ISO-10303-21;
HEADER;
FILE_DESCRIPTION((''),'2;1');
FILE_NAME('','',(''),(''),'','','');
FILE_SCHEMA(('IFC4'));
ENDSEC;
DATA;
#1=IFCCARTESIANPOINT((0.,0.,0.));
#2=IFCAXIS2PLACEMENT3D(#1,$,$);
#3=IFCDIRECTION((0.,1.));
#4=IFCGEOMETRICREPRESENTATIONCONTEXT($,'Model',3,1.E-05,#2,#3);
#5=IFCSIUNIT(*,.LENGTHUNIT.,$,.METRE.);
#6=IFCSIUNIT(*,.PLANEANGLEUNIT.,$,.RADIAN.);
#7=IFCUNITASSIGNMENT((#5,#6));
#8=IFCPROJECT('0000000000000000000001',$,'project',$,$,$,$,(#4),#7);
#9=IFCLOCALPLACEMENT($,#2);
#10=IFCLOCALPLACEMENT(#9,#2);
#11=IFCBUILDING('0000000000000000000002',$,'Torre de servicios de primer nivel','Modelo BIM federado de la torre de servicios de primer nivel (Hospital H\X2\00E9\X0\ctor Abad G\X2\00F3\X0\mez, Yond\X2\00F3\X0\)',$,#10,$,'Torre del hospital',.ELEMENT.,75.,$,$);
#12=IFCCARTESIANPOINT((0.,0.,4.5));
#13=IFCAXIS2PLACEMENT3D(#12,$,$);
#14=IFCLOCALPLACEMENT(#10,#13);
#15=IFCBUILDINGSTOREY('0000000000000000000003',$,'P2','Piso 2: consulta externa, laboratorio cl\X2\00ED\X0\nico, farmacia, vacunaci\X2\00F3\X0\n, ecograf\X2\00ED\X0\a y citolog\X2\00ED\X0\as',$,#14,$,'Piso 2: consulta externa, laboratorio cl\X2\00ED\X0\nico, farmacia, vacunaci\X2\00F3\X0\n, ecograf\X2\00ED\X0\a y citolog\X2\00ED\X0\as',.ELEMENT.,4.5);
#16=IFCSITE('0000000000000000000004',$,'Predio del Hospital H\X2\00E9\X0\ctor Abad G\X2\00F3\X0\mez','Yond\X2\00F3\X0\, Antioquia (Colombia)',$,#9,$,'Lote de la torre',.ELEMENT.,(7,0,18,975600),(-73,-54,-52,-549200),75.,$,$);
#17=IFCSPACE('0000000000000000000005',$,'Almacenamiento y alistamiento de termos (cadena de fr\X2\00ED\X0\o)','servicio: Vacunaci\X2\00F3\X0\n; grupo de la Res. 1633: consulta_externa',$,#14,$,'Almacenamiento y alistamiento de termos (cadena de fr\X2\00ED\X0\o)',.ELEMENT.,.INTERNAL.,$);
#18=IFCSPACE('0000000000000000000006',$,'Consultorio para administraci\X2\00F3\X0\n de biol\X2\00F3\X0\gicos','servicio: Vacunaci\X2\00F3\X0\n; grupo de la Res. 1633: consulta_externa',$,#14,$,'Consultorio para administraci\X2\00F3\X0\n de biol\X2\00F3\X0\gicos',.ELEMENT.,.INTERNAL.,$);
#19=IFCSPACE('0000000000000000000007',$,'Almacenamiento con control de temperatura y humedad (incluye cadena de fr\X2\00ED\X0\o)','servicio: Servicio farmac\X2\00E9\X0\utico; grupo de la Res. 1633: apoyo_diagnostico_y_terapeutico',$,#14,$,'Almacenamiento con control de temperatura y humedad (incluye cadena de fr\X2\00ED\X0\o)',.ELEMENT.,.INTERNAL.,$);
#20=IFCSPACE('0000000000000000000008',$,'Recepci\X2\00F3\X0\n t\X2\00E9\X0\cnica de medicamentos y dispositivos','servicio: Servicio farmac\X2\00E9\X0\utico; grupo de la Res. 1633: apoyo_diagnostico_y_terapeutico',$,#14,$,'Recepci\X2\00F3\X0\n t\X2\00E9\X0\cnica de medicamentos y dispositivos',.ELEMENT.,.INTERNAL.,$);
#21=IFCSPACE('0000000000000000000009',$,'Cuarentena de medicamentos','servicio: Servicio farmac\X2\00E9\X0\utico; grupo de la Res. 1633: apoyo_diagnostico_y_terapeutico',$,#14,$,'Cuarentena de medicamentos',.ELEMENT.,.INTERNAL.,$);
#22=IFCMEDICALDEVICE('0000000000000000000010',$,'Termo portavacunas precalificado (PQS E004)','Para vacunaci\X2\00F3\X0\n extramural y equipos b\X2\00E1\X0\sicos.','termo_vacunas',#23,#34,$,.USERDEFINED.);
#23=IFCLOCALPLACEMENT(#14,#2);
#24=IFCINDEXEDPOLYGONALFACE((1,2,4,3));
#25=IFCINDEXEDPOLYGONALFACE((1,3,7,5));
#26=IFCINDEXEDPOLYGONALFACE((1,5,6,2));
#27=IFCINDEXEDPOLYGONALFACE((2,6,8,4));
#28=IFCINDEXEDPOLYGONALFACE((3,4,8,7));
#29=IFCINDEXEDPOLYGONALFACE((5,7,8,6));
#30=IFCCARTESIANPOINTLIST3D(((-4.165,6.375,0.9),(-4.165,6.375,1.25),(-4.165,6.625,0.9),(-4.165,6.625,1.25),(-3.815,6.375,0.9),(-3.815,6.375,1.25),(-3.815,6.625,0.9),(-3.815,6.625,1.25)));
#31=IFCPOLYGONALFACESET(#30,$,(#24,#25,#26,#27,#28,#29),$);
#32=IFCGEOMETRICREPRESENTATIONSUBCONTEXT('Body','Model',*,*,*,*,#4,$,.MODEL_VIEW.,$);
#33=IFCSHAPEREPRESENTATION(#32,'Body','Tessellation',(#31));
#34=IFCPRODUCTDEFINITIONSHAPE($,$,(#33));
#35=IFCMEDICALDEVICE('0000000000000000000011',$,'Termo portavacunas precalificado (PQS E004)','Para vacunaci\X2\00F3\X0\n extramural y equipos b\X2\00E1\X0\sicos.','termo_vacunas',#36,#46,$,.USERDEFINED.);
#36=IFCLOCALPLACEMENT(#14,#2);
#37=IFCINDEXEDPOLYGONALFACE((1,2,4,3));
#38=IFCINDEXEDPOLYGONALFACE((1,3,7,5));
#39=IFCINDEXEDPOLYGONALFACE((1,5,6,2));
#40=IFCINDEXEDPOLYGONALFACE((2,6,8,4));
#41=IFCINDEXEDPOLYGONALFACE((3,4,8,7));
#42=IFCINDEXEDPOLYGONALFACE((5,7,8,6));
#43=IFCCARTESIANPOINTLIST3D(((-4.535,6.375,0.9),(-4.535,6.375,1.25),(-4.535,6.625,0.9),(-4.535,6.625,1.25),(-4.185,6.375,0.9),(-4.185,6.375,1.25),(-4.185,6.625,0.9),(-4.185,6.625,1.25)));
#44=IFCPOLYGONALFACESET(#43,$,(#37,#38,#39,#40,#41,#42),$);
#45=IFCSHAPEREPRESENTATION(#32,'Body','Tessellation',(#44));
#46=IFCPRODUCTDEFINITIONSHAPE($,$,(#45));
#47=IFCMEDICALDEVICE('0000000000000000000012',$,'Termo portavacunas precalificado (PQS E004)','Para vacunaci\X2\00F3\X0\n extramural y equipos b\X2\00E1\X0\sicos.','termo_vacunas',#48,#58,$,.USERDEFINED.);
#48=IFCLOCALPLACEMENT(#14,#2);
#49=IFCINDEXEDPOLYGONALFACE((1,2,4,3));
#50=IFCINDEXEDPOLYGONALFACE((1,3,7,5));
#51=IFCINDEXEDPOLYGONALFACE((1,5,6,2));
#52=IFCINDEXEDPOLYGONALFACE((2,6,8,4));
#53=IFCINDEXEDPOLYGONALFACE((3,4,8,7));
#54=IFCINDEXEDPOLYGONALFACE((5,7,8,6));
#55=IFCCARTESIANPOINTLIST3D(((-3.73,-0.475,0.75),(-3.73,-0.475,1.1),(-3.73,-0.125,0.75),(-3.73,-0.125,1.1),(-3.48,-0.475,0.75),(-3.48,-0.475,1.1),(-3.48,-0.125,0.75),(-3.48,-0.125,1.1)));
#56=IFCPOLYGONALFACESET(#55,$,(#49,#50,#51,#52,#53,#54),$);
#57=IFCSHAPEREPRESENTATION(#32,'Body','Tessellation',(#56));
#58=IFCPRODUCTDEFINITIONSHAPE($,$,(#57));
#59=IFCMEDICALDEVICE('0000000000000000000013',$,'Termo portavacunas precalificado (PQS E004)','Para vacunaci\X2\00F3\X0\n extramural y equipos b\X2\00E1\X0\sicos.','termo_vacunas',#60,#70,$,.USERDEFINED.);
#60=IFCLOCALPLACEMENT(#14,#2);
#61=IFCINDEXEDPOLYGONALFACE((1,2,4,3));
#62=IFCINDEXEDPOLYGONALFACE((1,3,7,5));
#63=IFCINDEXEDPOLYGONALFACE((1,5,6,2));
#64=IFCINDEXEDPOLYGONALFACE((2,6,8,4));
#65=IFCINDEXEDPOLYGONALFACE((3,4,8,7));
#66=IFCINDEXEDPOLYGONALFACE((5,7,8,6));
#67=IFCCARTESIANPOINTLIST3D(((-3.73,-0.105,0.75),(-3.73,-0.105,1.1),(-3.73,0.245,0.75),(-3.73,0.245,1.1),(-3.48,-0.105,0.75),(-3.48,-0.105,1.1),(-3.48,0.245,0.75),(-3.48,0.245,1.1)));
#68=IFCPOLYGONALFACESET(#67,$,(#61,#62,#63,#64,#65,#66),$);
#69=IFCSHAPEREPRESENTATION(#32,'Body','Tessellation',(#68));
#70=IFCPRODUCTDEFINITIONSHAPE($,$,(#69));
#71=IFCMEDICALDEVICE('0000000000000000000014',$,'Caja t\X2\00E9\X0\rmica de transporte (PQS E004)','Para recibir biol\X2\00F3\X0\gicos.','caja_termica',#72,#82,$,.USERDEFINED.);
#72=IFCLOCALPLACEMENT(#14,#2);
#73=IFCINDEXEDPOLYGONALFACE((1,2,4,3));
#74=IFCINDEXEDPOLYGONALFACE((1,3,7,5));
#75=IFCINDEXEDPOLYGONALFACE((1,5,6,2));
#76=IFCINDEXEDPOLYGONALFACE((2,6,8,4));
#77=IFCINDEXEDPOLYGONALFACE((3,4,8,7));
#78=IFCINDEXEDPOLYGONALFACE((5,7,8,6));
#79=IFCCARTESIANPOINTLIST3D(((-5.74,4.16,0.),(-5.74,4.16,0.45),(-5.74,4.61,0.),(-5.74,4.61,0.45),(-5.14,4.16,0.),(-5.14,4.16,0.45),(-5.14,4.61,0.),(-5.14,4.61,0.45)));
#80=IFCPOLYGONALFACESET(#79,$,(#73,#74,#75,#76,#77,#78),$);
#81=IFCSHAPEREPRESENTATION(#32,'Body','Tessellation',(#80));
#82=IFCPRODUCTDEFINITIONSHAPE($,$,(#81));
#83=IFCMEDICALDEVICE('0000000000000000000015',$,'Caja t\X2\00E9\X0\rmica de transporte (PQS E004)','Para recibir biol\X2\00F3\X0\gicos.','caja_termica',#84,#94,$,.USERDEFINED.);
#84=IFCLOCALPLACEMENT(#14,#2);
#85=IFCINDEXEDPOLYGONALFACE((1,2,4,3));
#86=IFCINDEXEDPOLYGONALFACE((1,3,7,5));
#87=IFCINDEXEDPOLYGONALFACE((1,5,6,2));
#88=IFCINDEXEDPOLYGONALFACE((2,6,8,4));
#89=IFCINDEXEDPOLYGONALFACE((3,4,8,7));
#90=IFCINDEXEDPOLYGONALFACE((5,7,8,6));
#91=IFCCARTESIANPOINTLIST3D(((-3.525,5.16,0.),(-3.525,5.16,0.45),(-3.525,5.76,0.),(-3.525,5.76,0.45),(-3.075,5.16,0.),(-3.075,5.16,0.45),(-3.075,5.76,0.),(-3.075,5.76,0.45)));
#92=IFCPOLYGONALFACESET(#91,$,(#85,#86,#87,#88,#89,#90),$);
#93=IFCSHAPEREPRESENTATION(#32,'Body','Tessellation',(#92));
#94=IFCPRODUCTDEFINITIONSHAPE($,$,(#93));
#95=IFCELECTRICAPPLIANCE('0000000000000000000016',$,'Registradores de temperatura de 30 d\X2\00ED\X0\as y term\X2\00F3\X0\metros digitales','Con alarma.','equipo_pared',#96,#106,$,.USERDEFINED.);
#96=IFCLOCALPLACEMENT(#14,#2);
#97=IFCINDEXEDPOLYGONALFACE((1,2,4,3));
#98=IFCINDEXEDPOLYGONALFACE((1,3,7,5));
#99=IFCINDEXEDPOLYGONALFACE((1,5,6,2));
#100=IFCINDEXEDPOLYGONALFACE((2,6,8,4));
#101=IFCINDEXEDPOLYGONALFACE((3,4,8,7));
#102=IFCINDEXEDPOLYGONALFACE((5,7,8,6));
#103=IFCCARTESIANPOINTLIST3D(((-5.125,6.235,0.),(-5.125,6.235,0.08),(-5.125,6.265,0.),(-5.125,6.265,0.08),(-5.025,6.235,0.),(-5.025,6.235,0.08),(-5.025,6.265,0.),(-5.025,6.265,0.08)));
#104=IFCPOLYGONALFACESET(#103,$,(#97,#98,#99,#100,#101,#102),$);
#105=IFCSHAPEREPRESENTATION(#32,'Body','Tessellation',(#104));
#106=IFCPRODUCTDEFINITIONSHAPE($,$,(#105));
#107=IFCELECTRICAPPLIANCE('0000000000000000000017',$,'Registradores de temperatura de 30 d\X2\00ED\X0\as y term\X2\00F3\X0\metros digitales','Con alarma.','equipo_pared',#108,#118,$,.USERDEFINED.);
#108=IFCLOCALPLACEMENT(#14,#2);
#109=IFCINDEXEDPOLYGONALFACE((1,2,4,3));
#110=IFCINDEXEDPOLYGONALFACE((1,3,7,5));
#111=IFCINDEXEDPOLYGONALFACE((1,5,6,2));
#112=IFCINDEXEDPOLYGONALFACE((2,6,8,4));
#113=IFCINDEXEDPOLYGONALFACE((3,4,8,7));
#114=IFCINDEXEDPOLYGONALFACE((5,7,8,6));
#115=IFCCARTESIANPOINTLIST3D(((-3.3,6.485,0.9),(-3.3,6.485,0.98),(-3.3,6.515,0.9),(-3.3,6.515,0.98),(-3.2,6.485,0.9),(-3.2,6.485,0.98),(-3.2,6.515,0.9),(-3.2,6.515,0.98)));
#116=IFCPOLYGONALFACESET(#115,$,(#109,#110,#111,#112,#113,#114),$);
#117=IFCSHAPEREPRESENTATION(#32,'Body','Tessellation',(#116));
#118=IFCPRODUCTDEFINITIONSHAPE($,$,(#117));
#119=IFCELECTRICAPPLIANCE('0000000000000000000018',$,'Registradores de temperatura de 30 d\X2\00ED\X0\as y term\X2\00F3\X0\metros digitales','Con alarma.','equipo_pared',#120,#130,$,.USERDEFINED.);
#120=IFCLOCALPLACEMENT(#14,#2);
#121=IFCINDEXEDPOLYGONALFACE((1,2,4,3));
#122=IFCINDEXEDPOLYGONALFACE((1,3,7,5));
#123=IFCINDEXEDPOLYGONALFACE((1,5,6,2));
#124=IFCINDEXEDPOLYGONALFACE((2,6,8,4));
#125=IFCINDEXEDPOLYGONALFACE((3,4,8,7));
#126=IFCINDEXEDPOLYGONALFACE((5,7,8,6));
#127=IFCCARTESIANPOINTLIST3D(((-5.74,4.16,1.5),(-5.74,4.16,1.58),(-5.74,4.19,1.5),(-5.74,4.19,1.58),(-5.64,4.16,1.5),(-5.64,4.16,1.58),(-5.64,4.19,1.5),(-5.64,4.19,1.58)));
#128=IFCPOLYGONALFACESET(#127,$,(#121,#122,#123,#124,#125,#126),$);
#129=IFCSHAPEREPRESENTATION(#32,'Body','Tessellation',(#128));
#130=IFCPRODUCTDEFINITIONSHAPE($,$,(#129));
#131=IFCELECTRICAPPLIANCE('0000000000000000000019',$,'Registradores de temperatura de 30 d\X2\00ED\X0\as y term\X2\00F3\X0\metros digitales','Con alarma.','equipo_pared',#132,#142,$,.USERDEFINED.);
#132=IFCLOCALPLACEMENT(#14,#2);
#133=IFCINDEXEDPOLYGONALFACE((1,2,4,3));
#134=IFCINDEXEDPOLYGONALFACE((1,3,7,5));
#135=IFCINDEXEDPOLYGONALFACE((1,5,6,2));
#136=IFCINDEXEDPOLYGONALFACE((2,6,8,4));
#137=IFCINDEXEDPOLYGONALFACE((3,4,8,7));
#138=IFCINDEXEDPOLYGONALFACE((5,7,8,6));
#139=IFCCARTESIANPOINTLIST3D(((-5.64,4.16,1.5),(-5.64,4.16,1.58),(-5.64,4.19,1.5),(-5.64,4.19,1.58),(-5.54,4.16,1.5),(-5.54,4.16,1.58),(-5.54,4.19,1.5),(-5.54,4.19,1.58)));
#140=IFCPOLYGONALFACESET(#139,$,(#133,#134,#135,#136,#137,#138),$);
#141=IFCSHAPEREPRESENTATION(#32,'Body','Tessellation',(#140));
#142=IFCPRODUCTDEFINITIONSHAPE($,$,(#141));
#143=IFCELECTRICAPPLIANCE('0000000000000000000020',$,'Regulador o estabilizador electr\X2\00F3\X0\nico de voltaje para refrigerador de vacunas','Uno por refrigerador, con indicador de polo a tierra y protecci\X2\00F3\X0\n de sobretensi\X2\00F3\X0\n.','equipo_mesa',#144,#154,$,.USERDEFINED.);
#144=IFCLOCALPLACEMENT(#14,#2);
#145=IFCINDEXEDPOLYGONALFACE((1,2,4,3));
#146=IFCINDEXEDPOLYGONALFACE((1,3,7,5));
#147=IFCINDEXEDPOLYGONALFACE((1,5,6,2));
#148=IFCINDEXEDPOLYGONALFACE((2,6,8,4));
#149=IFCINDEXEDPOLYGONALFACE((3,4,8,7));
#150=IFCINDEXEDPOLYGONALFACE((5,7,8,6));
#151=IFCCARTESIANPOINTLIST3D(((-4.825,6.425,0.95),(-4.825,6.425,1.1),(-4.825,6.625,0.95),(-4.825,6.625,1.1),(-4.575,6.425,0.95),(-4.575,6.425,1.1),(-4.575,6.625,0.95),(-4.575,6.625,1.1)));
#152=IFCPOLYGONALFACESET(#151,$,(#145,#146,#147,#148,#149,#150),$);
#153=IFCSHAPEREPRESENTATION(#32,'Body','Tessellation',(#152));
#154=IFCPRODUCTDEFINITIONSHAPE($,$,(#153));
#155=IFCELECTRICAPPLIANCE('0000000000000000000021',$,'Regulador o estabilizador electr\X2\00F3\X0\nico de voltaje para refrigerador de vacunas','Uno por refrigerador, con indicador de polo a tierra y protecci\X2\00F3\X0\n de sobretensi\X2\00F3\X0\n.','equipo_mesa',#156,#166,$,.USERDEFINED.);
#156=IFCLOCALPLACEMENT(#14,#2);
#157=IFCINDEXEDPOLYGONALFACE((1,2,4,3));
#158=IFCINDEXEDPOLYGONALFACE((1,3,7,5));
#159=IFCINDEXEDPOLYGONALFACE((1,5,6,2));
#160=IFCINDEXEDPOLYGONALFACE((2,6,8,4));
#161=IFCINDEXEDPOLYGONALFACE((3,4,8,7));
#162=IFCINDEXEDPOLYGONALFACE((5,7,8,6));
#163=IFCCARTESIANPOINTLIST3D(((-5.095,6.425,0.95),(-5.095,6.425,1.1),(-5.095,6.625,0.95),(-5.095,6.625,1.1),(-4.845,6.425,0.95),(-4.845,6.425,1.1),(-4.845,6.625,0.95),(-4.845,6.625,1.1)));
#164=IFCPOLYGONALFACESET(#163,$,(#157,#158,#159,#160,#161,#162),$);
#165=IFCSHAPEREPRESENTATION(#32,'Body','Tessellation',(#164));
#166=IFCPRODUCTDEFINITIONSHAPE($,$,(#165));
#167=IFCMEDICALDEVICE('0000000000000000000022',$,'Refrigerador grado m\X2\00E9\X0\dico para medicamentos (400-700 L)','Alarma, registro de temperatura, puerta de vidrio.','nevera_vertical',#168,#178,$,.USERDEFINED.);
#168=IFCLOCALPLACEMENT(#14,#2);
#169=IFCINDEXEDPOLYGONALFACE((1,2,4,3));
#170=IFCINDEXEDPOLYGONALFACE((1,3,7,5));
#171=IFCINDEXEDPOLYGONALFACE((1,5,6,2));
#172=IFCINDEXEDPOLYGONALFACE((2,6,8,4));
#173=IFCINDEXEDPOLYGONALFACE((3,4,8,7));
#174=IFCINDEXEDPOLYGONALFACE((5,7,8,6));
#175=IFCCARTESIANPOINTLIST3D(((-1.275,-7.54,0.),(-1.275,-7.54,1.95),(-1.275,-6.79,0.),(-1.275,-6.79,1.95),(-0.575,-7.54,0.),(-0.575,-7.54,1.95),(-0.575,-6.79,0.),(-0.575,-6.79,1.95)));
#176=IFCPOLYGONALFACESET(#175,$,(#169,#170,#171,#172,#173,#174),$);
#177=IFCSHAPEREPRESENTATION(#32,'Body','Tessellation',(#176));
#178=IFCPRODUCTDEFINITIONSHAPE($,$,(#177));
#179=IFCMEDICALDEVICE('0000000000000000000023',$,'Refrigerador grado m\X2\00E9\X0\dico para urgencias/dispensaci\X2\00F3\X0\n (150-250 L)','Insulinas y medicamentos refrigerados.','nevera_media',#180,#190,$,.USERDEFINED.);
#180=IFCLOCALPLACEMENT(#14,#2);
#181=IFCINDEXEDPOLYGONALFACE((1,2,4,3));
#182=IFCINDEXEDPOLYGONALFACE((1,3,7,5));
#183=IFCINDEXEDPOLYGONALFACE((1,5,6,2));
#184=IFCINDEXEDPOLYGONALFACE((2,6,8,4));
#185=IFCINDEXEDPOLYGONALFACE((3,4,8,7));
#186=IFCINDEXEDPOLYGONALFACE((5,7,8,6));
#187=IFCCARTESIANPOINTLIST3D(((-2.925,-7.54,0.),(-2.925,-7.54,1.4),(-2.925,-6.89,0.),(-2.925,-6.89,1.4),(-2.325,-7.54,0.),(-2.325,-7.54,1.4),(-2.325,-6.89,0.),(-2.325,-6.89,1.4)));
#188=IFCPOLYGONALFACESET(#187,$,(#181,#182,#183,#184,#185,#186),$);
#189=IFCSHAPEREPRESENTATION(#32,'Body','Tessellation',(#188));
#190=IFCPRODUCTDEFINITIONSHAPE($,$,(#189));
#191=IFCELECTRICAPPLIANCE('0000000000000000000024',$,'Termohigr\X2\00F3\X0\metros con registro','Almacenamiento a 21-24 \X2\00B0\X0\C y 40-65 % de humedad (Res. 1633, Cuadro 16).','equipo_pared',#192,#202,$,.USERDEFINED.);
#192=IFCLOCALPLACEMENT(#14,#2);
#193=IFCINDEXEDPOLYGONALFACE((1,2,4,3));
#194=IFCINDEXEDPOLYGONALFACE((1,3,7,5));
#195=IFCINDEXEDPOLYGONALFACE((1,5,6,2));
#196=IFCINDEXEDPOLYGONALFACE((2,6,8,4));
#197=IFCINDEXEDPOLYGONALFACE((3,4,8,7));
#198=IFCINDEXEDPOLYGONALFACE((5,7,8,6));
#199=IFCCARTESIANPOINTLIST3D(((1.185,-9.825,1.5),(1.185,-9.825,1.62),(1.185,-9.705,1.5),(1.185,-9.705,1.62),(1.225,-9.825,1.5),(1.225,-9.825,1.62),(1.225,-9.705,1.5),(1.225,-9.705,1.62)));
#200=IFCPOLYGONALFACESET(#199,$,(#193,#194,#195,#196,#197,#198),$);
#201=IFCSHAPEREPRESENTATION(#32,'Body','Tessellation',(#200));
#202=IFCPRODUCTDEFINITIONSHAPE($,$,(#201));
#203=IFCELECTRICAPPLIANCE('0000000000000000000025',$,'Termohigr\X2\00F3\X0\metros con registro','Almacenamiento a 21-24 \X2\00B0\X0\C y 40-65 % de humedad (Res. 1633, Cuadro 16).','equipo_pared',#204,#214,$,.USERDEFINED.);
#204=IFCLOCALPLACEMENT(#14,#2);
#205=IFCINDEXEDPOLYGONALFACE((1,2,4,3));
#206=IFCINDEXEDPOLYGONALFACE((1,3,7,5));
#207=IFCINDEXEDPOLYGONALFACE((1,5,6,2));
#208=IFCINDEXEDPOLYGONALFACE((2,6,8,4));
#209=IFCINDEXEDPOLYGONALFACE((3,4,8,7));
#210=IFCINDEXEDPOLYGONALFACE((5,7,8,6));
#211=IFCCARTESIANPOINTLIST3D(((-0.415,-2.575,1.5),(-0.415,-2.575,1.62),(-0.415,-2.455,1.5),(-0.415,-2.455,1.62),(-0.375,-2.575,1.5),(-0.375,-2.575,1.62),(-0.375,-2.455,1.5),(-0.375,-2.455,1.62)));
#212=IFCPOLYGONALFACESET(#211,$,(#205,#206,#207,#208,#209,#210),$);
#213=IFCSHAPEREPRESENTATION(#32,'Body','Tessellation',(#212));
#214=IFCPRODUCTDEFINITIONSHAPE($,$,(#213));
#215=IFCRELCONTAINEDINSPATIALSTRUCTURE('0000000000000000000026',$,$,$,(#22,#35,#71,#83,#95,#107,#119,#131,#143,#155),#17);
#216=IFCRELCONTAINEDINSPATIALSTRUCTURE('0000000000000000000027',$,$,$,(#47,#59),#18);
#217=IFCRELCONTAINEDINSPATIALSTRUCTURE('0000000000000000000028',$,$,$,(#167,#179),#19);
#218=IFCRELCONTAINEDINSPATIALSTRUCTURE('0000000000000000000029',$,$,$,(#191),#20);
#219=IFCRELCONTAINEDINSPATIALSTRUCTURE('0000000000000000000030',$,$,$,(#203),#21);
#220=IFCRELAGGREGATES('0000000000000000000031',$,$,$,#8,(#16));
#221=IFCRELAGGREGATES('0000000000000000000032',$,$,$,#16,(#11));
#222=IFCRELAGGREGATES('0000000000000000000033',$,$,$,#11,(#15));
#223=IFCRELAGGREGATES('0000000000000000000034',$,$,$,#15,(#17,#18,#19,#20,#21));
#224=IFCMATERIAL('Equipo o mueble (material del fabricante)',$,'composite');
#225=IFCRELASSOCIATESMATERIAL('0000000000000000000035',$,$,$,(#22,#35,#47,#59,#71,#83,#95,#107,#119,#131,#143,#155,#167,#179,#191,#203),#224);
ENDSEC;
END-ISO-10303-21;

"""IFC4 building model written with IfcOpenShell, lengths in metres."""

from ifc_helpers import new_model, si_unit, direction, frame, origin, place, context, subcontext, project, spatial, rectangle, extrude, material, element, save


model = new_model("IFC4")

# Units and contexts
model_context = context("Model", 3, precision=1e-05, world=origin(), true_north=direction((0.0, 1.0)))
body_context = subcontext(model_context, "Body", "Model", "MODEL_VIEW")
ifc_project = project(units=[si_unit("LENGTHUNIT", "METRE"), si_unit("PLANEANGLEUNIT", "RADIAN")], contexts=[model_context])

# Site, building, storey, space
site_placement = place(None, origin())
site = spatial("IfcSite", under=ifc_project, at=site_placement, Name="Predio del Hospital Héctor Abad Gómez", Description="Yondó, Antioquia (Colombia)", LongName="Lote de la torre", CompositionType="ELEMENT", RefLatitude=(7, 0, 18, 975600), RefLongitude=(-73, -54, -52, -549200), RefElevation=75.0)
building_placement = place(site_placement, origin())
building = spatial("IfcBuilding", under=site, at=building_placement, Name="Torre de servicios de primer nivel", Description="Modelo BIM federado de la torre de servicios de primer nivel (Hospital Héctor Abad Gómez, Yondó)", LongName="Torre del hospital", CompositionType="ELEMENT", ElevationOfRefHeight=75.0)
placement = place(building_placement, frame((0.0, 0.0, 4.5)))
storey = spatial("IfcBuildingStorey", under=building, at=placement, Name="P2", Description="Piso 2: consulta externa, laboratorio clínico, farmacia, vacunación, ecografía y citologías", LongName="Piso 2: consulta externa, laboratorio clínico, farmacia, vacunación, ecografía y citologías", CompositionType="ELEMENT", Elevation=4.5)
space_1 = spatial("IfcSpace", under=storey, at=placement, Name="Almacenamiento y alistamiento de termos (cadena de frío)", Description="servicio: Vacunación; grupo de la Res. 1633: consulta_externa", LongName="Almacenamiento y alistamiento de termos (cadena de frío)", CompositionType="ELEMENT", PredefinedType="INTERNAL")

# Medical devices
ifc_material = material(Name="Equipo o mueble (material del fabricante)", Category="composite")
element("IfcMedicalDevice", 1, at=placement, inside=space_1, material=ifc_material, Name="Termo portavacunas precalificado (PQS E004)", Description="Para vacunación extramural y equipos básicos.", ObjectType="termo_vacunas", PredefinedType="USERDEFINED", context=body_context, shape_type="SweptSolid", body=[
    extrude(rectangle(XDim=0.35, YDim=0.25), frame((-3.99, 6.5, 0.9), z_axis=(0.0, 0.0, 1.0), x_axis=(-1.0, 0.0, 0.0)), (0.0, 0.0, 1.0), 0.35),
])
element("IfcMedicalDevice", 2, at=placement, inside=space_1, material=ifc_material, Name="Termo portavacunas precalificado (PQS E004)", Description="Para vacunación extramural y equipos básicos.", ObjectType="termo_vacunas", PredefinedType="USERDEFINED", context=body_context, shape_type="SweptSolid", body=[
    extrude(rectangle(XDim=0.35, YDim=0.25), frame((-4.36, 6.5, 0.9), z_axis=(0.0, 0.0, 1.0), x_axis=(-1.0, 0.0, 0.0)), (0.0, 0.0, 1.0), 0.35),
])

# Shared definitions
space_2 = spatial("IfcSpace", under=storey, at=placement, Name="Consultorio para administración de biológicos", Description="servicio: Vacunación; grupo de la Res. 1633: consulta_externa", LongName="Consultorio para administración de biológicos", CompositionType="ELEMENT", PredefinedType="INTERNAL")

# Medical devices
element("IfcMedicalDevice", 3, at=placement, inside=space_2, material=ifc_material, Name="Termo portavacunas precalificado (PQS E004)", Description="Para vacunación extramural y equipos básicos.", ObjectType="termo_vacunas", PredefinedType="USERDEFINED", context=body_context, shape_type="SweptSolid", body=[
    extrude(rectangle(XDim=0.35, YDim=0.25), frame((-3.605, -0.3, 0.75), z_axis=(0.0, 0.0, 1.0), x_axis=(0.0, 1.0, 0.0)), (0.0, 0.0, 1.0), 0.35),
])
element("IfcMedicalDevice", 4, at=placement, inside=space_2, material=ifc_material, Name="Termo portavacunas precalificado (PQS E004)", Description="Para vacunación extramural y equipos básicos.", ObjectType="termo_vacunas", PredefinedType="USERDEFINED", context=body_context, shape_type="SweptSolid", body=[
    extrude(rectangle(XDim=0.35, YDim=0.25), frame((-3.605, 0.07, 0.75), z_axis=(0.0, 0.0, 1.0), x_axis=(0.0, 1.0, 0.0)), (0.0, 0.0, 1.0), 0.35),
])
element("IfcMedicalDevice", 5, at=placement, inside=space_1, material=ifc_material, Name="Caja térmica de transporte (PQS E004)", Description="Para recibir biológicos.", ObjectType="caja_termica", PredefinedType="USERDEFINED", context=body_context, shape_type="SweptSolid", body=[
    extrude(rectangle(XDim=0.6, YDim=0.45), frame((-5.44, 4.385, 0.0)), (0.0, 0.0, 1.0), 0.45),
])
element("IfcMedicalDevice", 6, at=placement, inside=space_1, material=ifc_material, Name="Caja térmica de transporte (PQS E004)", Description="Para recibir biológicos.", ObjectType="caja_termica", PredefinedType="USERDEFINED", context=body_context, shape_type="SweptSolid", body=[
    extrude(rectangle(XDim=0.6, YDim=0.45), frame((-3.3, 5.46, 0.0), z_axis=(0.0, 0.0, 1.0), x_axis=(0.0, 1.0, 0.0)), (0.0, 0.0, 1.0), 0.45),
])

# Electric appliances
element("IfcElectricAppliance", 7, at=placement, inside=space_1, material=ifc_material, Name="Registradores de temperatura de 30 días y termómetros digitales", Description="Con alarma.", ObjectType="equipo_pared", PredefinedType="USERDEFINED", context=body_context, shape_type="SweptSolid", body=[
    extrude(rectangle(XDim=0.1, YDim=0.03), frame((-5.075, 6.25, 0.0), z_axis=(0.0, 0.0, 1.0), x_axis=(-1.0, 0.0, 0.0)), (0.0, 0.0, 1.0), 0.08),
])
element("IfcElectricAppliance", 8, at=placement, inside=space_1, material=ifc_material, Name="Registradores de temperatura de 30 días y termómetros digitales", Description="Con alarma.", ObjectType="equipo_pared", PredefinedType="USERDEFINED", context=body_context, shape_type="SweptSolid", body=[
    extrude(rectangle(XDim=0.1, YDim=0.03), frame((-3.25, 6.5, 0.9), z_axis=(0.0, 0.0, 1.0), x_axis=(-1.0, 0.0, 0.0)), (0.0, 0.0, 1.0), 0.08),
])
element("IfcElectricAppliance", 9, at=placement, inside=space_1, material=ifc_material, Name="Registradores de temperatura de 30 días y termómetros digitales", Description="Con alarma.", ObjectType="equipo_pared", PredefinedType="USERDEFINED", context=body_context, shape_type="SweptSolid", body=[
    extrude(rectangle(XDim=0.1, YDim=0.03), frame((-5.69, 4.175, 1.5)), (0.0, 0.0, 1.0), 0.08),
])
element("IfcElectricAppliance", 10, at=placement, inside=space_1, material=ifc_material, Name="Registradores de temperatura de 30 días y termómetros digitales", Description="Con alarma.", ObjectType="equipo_pared", PredefinedType="USERDEFINED", context=body_context, shape_type="SweptSolid", body=[
    extrude(rectangle(XDim=0.1, YDim=0.03), frame((-5.59, 4.175, 1.5)), (0.0, 0.0, 1.0), 0.08),
])
element("IfcElectricAppliance", 11, at=placement, inside=space_1, material=ifc_material, Name="Regulador o estabilizador electrónico de voltaje para refrigerador de vacunas", Description="Uno por refrigerador, con indicador de polo a tierra y protección de sobretensión.", ObjectType="equipo_mesa", PredefinedType="USERDEFINED", context=body_context, shape_type="SweptSolid", body=[
    extrude(rectangle(XDim=0.25, YDim=0.2), frame((-4.7, 6.525, 0.95), z_axis=(0.0, 0.0, 1.0), x_axis=(-1.0, 0.0, 0.0)), (0.0, 0.0, 1.0), 0.15),
])
element("IfcElectricAppliance", 12, at=placement, inside=space_1, material=ifc_material, Name="Regulador o estabilizador electrónico de voltaje para refrigerador de vacunas", Description="Uno por refrigerador, con indicador de polo a tierra y protección de sobretensión.", ObjectType="equipo_mesa", PredefinedType="USERDEFINED", context=body_context, shape_type="SweptSolid", body=[
    extrude(rectangle(XDim=0.25, YDim=0.2), frame((-4.97, 6.525, 0.95), z_axis=(0.0, 0.0, 1.0), x_axis=(-1.0, 0.0, 0.0)), (0.0, 0.0, 1.0), 0.15),
])

# Shared definitions
space_3 = spatial("IfcSpace", under=storey, at=placement, Name="Almacenamiento con control de temperatura y humedad (incluye cadena de frío)", Description="servicio: Servicio farmacéutico; grupo de la Res. 1633: apoyo_diagnostico_y_terapeutico", LongName="Almacenamiento con control de temperatura y humedad (incluye cadena de frío)", CompositionType="ELEMENT", PredefinedType="INTERNAL")

# Medical devices
element("IfcMedicalDevice", 13, at=placement, inside=space_3, material=ifc_material, Name="Refrigerador grado médico para medicamentos (400-700 L)", Description="Alarma, registro de temperatura, puerta de vidrio.", ObjectType="nevera_vertical", PredefinedType="USERDEFINED", context=body_context, shape_type="SweptSolid", body=[
    extrude(rectangle(XDim=0.7, YDim=0.75), frame((-0.925, -7.165, 0.0)), (0.0, 0.0, 1.0), 1.95),
])
element("IfcMedicalDevice", 14, at=placement, inside=space_3, material=ifc_material, Name="Refrigerador grado médico para urgencias/dispensación (150-250 L)", Description="Insulinas y medicamentos refrigerados.", ObjectType="nevera_media", PredefinedType="USERDEFINED", context=body_context, shape_type="SweptSolid", body=[
    extrude(rectangle(XDim=0.6, YDim=0.65), frame((-2.625, -7.215, 0.0)), (0.0, 0.0, 1.0), 1.4),
])

# Shared definitions
space_4 = spatial("IfcSpace", under=storey, at=placement, Name="Recepción técnica de medicamentos y dispositivos", Description="servicio: Servicio farmacéutico; grupo de la Res. 1633: apoyo_diagnostico_y_terapeutico", LongName="Recepción técnica de medicamentos y dispositivos", CompositionType="ELEMENT", PredefinedType="INTERNAL")

# Electric appliance
element("IfcElectricAppliance", 15, at=placement, inside=space_4, material=ifc_material, Name="Termohigrómetros con registro", Description="Almacenamiento a 21-24 °C y 40-65 % de humedad (Res. 1633, Cuadro 16).", ObjectType="equipo_pared", PredefinedType="USERDEFINED", context=body_context, shape_type="SweptSolid", body=[
    extrude(rectangle(XDim=0.12, YDim=0.04), frame((1.205, -9.765, 1.5), z_axis=(0.0, 0.0, 1.0), x_axis=(0.0, 1.0, 0.0)), (0.0, 0.0, 1.0), 0.12),
])

# Shared definitions
space_5 = spatial("IfcSpace", under=storey, at=placement, Name="Cuarentena de medicamentos", Description="servicio: Servicio farmacéutico; grupo de la Res. 1633: apoyo_diagnostico_y_terapeutico", LongName="Cuarentena de medicamentos", CompositionType="ELEMENT", PredefinedType="INTERNAL")

# Electric appliance
element("IfcElectricAppliance", 16, at=placement, inside=space_5, material=ifc_material, Name="Termohigrómetros con registro", Description="Almacenamiento a 21-24 °C y 40-65 % de humedad (Res. 1633, Cuadro 16).", ObjectType="equipo_pared", PredefinedType="USERDEFINED", context=body_context, shape_type="SweptSolid", body=[
    extrude(rectangle(XDim=0.12, YDim=0.04), frame((-0.395, -2.515, 1.5), z_axis=(0.0, 0.0, 1.0), x_axis=(0.0, 1.0, 0.0)), (0.0, 0.0, 1.0), 0.12),
])

save(model, "model.ifc")
